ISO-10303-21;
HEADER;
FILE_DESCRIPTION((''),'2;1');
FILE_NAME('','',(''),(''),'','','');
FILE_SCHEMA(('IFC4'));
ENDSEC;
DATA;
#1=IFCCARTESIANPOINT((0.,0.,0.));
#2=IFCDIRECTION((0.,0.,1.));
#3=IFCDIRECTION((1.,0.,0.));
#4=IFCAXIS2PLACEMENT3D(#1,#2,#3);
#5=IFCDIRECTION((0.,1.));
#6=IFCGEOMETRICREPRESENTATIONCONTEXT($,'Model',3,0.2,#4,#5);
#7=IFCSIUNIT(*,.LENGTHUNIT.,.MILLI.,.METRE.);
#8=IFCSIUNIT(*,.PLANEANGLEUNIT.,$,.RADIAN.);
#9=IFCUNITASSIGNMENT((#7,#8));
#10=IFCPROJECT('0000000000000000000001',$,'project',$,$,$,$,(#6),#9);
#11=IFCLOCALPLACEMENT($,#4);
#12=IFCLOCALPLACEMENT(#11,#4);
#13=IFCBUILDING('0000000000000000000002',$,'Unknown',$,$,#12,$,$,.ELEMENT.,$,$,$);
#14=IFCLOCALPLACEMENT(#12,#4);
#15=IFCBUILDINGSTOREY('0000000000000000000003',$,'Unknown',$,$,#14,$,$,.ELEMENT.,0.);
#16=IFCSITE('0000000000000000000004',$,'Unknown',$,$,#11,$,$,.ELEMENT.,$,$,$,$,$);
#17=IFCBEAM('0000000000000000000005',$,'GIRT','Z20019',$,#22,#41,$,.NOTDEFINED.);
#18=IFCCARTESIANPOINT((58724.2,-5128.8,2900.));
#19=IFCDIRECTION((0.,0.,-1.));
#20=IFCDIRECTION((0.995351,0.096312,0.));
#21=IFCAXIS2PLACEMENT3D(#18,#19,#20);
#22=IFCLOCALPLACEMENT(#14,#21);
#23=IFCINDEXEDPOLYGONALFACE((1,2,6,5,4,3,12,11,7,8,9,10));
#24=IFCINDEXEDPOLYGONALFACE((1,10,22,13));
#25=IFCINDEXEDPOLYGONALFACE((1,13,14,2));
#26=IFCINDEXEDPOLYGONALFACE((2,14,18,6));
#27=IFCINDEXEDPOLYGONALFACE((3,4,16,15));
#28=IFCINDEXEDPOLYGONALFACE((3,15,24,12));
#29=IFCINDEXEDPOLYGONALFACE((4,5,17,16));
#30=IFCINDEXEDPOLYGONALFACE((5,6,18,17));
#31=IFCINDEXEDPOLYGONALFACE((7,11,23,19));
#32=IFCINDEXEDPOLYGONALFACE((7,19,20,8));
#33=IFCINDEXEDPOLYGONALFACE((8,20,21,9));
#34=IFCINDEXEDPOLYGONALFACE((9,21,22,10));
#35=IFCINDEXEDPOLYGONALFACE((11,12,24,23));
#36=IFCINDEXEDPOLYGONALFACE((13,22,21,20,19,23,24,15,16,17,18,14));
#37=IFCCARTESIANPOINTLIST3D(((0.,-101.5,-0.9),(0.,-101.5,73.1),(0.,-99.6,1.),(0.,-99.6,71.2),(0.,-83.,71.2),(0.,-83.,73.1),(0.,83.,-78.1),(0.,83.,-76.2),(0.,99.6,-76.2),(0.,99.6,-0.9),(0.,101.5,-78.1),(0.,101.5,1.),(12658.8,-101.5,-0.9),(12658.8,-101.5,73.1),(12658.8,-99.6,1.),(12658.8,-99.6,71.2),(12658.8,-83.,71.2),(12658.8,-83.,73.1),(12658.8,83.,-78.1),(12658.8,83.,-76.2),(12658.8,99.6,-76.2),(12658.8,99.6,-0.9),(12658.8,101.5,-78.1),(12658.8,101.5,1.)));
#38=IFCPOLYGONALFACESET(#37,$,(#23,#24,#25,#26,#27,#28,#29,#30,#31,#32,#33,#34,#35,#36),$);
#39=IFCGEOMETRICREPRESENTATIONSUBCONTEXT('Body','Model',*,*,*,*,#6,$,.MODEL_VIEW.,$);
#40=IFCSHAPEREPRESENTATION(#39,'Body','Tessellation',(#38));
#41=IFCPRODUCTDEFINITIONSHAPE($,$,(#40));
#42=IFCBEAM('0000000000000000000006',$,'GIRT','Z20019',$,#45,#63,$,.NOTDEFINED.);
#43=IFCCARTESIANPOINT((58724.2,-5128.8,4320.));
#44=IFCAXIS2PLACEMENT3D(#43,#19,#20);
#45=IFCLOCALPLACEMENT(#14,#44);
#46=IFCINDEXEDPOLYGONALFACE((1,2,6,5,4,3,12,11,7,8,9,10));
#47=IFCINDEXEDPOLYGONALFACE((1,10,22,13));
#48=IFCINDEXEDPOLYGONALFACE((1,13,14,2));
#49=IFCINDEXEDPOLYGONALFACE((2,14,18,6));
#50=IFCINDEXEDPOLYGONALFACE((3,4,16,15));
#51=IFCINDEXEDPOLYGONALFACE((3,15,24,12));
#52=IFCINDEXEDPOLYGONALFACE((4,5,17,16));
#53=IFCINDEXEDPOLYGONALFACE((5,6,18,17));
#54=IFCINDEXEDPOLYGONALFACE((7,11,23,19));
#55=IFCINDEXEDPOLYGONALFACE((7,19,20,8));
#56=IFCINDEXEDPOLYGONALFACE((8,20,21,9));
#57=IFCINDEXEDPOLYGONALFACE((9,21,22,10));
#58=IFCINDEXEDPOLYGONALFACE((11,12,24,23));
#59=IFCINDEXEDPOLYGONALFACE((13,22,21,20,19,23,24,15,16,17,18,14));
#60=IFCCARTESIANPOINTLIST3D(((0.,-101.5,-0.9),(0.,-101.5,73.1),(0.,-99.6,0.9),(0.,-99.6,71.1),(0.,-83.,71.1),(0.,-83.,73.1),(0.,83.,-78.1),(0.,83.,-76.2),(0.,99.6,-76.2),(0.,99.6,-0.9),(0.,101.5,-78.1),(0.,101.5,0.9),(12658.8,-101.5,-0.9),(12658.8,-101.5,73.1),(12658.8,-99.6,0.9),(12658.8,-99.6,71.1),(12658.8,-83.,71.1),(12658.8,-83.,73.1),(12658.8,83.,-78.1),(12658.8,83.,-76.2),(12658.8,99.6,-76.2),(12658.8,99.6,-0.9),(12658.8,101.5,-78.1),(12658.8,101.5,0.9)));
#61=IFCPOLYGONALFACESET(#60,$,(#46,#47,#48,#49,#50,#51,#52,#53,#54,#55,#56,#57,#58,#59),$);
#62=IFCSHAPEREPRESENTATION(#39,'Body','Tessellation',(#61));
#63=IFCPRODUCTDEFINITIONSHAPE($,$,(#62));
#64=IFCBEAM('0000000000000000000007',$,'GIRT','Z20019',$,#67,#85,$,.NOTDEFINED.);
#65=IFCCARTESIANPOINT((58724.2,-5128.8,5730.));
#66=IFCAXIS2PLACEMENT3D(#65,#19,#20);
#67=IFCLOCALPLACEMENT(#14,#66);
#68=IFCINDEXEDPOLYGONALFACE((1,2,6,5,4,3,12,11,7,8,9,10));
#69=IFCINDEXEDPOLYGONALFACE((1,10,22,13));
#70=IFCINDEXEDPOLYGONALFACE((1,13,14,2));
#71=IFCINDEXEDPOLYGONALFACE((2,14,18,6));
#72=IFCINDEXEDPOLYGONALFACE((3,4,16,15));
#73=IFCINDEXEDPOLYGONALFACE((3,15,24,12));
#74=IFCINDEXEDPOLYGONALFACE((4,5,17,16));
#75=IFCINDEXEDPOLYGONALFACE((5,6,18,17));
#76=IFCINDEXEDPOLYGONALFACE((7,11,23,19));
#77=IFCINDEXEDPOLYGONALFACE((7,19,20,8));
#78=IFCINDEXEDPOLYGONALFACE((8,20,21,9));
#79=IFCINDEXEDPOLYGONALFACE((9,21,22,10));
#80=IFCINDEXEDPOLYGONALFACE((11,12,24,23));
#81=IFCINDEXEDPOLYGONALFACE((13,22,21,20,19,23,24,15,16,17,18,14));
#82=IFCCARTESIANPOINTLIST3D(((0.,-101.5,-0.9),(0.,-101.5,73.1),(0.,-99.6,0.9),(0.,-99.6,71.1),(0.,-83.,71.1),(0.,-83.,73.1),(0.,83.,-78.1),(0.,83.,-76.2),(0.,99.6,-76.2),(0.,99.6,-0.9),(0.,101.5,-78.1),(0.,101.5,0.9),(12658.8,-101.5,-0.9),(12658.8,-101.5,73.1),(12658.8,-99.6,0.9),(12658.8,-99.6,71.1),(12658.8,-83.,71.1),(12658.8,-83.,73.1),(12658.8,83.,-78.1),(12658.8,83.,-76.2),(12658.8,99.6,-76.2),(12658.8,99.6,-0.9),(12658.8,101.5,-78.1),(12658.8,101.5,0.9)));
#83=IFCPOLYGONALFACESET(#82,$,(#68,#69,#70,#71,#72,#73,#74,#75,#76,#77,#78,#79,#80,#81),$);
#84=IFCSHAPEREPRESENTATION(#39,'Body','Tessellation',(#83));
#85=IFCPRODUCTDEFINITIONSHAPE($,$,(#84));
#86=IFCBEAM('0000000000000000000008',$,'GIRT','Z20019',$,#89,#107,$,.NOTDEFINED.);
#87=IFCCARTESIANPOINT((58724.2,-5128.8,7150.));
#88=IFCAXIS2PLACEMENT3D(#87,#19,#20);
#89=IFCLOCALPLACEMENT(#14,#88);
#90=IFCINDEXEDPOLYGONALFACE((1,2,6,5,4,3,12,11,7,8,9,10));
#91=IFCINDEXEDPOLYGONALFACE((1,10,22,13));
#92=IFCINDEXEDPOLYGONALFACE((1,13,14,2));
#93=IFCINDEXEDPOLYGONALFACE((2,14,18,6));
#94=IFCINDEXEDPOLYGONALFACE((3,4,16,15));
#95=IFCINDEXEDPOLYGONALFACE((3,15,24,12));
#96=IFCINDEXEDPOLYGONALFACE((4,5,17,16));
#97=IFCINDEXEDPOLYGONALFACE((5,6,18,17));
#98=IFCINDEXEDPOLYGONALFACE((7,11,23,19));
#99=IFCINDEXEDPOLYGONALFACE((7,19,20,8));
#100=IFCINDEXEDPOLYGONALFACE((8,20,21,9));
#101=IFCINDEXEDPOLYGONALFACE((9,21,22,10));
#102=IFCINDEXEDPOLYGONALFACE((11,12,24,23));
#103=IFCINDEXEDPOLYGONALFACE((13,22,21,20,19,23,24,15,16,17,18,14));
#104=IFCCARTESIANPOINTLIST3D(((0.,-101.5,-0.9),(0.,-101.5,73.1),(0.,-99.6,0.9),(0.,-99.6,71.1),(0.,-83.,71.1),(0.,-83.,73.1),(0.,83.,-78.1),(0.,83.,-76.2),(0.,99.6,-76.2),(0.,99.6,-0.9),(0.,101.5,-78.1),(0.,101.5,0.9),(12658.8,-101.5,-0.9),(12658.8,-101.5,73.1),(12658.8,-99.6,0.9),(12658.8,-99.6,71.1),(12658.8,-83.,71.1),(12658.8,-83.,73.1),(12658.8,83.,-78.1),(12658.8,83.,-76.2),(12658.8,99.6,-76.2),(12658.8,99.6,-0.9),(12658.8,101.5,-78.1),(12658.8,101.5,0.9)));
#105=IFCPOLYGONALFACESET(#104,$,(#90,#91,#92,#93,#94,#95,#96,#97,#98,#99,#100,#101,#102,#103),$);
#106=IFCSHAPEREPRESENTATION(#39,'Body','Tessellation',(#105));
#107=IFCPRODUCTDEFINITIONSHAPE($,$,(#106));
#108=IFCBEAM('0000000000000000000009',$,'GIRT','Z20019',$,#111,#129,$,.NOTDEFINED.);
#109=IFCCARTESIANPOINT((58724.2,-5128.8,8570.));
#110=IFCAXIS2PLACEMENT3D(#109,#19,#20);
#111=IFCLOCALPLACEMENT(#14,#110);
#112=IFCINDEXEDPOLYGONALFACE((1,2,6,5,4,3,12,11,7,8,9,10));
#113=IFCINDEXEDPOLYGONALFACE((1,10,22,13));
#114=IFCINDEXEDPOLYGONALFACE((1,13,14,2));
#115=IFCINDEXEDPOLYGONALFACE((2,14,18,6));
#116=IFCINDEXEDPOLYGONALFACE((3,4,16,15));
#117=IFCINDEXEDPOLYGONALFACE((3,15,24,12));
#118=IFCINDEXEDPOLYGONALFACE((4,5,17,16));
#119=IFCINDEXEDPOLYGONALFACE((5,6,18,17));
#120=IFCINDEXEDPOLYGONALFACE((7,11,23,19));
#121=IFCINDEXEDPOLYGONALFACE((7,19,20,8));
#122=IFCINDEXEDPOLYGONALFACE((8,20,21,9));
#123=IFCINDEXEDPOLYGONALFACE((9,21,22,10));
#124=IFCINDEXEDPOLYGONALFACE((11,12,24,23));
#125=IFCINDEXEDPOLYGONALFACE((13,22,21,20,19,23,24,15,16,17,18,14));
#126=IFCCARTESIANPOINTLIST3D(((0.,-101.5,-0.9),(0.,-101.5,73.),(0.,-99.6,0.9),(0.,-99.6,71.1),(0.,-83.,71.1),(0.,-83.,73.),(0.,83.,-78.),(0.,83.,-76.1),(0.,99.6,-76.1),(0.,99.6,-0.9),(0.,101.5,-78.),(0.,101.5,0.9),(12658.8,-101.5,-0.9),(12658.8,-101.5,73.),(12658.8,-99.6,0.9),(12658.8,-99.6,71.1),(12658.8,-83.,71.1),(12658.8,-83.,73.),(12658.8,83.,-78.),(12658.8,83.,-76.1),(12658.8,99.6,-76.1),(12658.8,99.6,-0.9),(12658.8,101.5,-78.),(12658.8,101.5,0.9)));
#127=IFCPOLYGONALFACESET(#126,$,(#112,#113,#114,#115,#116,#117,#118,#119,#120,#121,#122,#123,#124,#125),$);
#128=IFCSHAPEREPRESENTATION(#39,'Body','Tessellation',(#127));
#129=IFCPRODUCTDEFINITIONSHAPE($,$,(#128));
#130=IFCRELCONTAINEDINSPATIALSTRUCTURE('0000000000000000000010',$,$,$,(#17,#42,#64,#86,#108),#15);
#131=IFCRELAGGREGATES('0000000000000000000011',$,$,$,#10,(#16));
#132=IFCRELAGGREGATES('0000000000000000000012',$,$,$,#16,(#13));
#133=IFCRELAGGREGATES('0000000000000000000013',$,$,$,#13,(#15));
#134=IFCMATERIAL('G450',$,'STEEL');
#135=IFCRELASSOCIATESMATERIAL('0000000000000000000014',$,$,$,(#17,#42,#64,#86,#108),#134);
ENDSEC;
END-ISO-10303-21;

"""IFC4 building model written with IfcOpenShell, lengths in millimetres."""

from ifc_helpers import new_model, si_unit, direction, frame, origin_with_axes, place, context, subcontext, project, spatial, line, indexed_curve, outline, extrude, material, element, save


model = new_model("IFC4")

# Units and contexts
model_context = context("Model", 3, precision=0.2, world=origin_with_axes(), true_north=direction((0.0, 1.0)))
body_context = subcontext(model_context, "Body", "Model", "MODEL_VIEW")
ifc_project = project(units=[si_unit("LENGTHUNIT", "METRE", prefix="MILLI"), si_unit("PLANEANGLEUNIT", "RADIAN")], contexts=[model_context])

# Site, building, storey
site_placement = place(None, origin_with_axes())
site = spatial("IfcSite", under=ifc_project, at=site_placement, Name="Unknown", CompositionType="ELEMENT")
building_placement = place(site_placement, origin_with_axes())
building = spatial("IfcBuilding", under=site, at=building_placement, Name="Unknown", CompositionType="ELEMENT")
storey_placement = place(building_placement, origin_with_axes())
storey = spatial("IfcBuildingStorey", under=building, at=storey_placement, Name="Unknown", CompositionType="ELEMENT", Elevation=0.0)

# Shared definitions
ifc_material_1 = material(Name="G450", Category="STEEL")

# Beams
for number, where, z_axis, x_axis, name in (
    (1, (58724.2, -5128.8, 2900.0), (0.0, 0.0, -1.0), (0.995351, 0.096312, 0.0), "GIRT"),
    (2, (58724.2, -5128.8, 4320.0), (0.0, 0.0, -1.0), (0.995351, 0.096312, 0.0), "GIRT"),
    (3, (58724.2, -5128.8, 5730.0), (0.0, 0.0, -1.0), (0.995351, 0.096312, 0.0), "GIRT"),
    (4, (58724.2, -5128.8, 7150.0), (0.0, 0.0, -1.0), (0.995351, 0.096312, 0.0), "GIRT"),
    (5, (58724.2, -5128.8, 8570.0), (0.0, 0.0, -1.0), (0.995351, 0.096312, 0.0), "GIRT"),
):
    element("IfcBeam", number, at=place(storey_placement, frame(where, z_axis=z_axis, x_axis=x_axis)), inside=storey, material=ifc_material_1, Name=name, Description="Z20019", PredefinedType="NOTDEFINED", context=body_context, shape_type="SolidModel", body=[
        extrude(outline(indexed_curve([(73.0, -101.5), (73.0, -83.0), (71.2, -83.0), (71.2, -99.6), (0.9, -99.6), (0.9, 101.5), (-78.0, 101.5), (-78.0, 83.0), (-76.2, 83.0), (-76.2, 99.6), (-0.9, 99.6), (-0.9, -101.5)], segments=[line(1, 2, 3, 4, 5, 6, 7, 8, 9, 10, 11, 12, 1)])), frame((0.0, 0.0, 0.0), z_axis=(-1.0, 0.0, 0.0), x_axis=(0.0, 0.0, 1.0)), (0.0, 0.0, -1.0), 12658.8),
    ])

save(model, "model.ifc")
